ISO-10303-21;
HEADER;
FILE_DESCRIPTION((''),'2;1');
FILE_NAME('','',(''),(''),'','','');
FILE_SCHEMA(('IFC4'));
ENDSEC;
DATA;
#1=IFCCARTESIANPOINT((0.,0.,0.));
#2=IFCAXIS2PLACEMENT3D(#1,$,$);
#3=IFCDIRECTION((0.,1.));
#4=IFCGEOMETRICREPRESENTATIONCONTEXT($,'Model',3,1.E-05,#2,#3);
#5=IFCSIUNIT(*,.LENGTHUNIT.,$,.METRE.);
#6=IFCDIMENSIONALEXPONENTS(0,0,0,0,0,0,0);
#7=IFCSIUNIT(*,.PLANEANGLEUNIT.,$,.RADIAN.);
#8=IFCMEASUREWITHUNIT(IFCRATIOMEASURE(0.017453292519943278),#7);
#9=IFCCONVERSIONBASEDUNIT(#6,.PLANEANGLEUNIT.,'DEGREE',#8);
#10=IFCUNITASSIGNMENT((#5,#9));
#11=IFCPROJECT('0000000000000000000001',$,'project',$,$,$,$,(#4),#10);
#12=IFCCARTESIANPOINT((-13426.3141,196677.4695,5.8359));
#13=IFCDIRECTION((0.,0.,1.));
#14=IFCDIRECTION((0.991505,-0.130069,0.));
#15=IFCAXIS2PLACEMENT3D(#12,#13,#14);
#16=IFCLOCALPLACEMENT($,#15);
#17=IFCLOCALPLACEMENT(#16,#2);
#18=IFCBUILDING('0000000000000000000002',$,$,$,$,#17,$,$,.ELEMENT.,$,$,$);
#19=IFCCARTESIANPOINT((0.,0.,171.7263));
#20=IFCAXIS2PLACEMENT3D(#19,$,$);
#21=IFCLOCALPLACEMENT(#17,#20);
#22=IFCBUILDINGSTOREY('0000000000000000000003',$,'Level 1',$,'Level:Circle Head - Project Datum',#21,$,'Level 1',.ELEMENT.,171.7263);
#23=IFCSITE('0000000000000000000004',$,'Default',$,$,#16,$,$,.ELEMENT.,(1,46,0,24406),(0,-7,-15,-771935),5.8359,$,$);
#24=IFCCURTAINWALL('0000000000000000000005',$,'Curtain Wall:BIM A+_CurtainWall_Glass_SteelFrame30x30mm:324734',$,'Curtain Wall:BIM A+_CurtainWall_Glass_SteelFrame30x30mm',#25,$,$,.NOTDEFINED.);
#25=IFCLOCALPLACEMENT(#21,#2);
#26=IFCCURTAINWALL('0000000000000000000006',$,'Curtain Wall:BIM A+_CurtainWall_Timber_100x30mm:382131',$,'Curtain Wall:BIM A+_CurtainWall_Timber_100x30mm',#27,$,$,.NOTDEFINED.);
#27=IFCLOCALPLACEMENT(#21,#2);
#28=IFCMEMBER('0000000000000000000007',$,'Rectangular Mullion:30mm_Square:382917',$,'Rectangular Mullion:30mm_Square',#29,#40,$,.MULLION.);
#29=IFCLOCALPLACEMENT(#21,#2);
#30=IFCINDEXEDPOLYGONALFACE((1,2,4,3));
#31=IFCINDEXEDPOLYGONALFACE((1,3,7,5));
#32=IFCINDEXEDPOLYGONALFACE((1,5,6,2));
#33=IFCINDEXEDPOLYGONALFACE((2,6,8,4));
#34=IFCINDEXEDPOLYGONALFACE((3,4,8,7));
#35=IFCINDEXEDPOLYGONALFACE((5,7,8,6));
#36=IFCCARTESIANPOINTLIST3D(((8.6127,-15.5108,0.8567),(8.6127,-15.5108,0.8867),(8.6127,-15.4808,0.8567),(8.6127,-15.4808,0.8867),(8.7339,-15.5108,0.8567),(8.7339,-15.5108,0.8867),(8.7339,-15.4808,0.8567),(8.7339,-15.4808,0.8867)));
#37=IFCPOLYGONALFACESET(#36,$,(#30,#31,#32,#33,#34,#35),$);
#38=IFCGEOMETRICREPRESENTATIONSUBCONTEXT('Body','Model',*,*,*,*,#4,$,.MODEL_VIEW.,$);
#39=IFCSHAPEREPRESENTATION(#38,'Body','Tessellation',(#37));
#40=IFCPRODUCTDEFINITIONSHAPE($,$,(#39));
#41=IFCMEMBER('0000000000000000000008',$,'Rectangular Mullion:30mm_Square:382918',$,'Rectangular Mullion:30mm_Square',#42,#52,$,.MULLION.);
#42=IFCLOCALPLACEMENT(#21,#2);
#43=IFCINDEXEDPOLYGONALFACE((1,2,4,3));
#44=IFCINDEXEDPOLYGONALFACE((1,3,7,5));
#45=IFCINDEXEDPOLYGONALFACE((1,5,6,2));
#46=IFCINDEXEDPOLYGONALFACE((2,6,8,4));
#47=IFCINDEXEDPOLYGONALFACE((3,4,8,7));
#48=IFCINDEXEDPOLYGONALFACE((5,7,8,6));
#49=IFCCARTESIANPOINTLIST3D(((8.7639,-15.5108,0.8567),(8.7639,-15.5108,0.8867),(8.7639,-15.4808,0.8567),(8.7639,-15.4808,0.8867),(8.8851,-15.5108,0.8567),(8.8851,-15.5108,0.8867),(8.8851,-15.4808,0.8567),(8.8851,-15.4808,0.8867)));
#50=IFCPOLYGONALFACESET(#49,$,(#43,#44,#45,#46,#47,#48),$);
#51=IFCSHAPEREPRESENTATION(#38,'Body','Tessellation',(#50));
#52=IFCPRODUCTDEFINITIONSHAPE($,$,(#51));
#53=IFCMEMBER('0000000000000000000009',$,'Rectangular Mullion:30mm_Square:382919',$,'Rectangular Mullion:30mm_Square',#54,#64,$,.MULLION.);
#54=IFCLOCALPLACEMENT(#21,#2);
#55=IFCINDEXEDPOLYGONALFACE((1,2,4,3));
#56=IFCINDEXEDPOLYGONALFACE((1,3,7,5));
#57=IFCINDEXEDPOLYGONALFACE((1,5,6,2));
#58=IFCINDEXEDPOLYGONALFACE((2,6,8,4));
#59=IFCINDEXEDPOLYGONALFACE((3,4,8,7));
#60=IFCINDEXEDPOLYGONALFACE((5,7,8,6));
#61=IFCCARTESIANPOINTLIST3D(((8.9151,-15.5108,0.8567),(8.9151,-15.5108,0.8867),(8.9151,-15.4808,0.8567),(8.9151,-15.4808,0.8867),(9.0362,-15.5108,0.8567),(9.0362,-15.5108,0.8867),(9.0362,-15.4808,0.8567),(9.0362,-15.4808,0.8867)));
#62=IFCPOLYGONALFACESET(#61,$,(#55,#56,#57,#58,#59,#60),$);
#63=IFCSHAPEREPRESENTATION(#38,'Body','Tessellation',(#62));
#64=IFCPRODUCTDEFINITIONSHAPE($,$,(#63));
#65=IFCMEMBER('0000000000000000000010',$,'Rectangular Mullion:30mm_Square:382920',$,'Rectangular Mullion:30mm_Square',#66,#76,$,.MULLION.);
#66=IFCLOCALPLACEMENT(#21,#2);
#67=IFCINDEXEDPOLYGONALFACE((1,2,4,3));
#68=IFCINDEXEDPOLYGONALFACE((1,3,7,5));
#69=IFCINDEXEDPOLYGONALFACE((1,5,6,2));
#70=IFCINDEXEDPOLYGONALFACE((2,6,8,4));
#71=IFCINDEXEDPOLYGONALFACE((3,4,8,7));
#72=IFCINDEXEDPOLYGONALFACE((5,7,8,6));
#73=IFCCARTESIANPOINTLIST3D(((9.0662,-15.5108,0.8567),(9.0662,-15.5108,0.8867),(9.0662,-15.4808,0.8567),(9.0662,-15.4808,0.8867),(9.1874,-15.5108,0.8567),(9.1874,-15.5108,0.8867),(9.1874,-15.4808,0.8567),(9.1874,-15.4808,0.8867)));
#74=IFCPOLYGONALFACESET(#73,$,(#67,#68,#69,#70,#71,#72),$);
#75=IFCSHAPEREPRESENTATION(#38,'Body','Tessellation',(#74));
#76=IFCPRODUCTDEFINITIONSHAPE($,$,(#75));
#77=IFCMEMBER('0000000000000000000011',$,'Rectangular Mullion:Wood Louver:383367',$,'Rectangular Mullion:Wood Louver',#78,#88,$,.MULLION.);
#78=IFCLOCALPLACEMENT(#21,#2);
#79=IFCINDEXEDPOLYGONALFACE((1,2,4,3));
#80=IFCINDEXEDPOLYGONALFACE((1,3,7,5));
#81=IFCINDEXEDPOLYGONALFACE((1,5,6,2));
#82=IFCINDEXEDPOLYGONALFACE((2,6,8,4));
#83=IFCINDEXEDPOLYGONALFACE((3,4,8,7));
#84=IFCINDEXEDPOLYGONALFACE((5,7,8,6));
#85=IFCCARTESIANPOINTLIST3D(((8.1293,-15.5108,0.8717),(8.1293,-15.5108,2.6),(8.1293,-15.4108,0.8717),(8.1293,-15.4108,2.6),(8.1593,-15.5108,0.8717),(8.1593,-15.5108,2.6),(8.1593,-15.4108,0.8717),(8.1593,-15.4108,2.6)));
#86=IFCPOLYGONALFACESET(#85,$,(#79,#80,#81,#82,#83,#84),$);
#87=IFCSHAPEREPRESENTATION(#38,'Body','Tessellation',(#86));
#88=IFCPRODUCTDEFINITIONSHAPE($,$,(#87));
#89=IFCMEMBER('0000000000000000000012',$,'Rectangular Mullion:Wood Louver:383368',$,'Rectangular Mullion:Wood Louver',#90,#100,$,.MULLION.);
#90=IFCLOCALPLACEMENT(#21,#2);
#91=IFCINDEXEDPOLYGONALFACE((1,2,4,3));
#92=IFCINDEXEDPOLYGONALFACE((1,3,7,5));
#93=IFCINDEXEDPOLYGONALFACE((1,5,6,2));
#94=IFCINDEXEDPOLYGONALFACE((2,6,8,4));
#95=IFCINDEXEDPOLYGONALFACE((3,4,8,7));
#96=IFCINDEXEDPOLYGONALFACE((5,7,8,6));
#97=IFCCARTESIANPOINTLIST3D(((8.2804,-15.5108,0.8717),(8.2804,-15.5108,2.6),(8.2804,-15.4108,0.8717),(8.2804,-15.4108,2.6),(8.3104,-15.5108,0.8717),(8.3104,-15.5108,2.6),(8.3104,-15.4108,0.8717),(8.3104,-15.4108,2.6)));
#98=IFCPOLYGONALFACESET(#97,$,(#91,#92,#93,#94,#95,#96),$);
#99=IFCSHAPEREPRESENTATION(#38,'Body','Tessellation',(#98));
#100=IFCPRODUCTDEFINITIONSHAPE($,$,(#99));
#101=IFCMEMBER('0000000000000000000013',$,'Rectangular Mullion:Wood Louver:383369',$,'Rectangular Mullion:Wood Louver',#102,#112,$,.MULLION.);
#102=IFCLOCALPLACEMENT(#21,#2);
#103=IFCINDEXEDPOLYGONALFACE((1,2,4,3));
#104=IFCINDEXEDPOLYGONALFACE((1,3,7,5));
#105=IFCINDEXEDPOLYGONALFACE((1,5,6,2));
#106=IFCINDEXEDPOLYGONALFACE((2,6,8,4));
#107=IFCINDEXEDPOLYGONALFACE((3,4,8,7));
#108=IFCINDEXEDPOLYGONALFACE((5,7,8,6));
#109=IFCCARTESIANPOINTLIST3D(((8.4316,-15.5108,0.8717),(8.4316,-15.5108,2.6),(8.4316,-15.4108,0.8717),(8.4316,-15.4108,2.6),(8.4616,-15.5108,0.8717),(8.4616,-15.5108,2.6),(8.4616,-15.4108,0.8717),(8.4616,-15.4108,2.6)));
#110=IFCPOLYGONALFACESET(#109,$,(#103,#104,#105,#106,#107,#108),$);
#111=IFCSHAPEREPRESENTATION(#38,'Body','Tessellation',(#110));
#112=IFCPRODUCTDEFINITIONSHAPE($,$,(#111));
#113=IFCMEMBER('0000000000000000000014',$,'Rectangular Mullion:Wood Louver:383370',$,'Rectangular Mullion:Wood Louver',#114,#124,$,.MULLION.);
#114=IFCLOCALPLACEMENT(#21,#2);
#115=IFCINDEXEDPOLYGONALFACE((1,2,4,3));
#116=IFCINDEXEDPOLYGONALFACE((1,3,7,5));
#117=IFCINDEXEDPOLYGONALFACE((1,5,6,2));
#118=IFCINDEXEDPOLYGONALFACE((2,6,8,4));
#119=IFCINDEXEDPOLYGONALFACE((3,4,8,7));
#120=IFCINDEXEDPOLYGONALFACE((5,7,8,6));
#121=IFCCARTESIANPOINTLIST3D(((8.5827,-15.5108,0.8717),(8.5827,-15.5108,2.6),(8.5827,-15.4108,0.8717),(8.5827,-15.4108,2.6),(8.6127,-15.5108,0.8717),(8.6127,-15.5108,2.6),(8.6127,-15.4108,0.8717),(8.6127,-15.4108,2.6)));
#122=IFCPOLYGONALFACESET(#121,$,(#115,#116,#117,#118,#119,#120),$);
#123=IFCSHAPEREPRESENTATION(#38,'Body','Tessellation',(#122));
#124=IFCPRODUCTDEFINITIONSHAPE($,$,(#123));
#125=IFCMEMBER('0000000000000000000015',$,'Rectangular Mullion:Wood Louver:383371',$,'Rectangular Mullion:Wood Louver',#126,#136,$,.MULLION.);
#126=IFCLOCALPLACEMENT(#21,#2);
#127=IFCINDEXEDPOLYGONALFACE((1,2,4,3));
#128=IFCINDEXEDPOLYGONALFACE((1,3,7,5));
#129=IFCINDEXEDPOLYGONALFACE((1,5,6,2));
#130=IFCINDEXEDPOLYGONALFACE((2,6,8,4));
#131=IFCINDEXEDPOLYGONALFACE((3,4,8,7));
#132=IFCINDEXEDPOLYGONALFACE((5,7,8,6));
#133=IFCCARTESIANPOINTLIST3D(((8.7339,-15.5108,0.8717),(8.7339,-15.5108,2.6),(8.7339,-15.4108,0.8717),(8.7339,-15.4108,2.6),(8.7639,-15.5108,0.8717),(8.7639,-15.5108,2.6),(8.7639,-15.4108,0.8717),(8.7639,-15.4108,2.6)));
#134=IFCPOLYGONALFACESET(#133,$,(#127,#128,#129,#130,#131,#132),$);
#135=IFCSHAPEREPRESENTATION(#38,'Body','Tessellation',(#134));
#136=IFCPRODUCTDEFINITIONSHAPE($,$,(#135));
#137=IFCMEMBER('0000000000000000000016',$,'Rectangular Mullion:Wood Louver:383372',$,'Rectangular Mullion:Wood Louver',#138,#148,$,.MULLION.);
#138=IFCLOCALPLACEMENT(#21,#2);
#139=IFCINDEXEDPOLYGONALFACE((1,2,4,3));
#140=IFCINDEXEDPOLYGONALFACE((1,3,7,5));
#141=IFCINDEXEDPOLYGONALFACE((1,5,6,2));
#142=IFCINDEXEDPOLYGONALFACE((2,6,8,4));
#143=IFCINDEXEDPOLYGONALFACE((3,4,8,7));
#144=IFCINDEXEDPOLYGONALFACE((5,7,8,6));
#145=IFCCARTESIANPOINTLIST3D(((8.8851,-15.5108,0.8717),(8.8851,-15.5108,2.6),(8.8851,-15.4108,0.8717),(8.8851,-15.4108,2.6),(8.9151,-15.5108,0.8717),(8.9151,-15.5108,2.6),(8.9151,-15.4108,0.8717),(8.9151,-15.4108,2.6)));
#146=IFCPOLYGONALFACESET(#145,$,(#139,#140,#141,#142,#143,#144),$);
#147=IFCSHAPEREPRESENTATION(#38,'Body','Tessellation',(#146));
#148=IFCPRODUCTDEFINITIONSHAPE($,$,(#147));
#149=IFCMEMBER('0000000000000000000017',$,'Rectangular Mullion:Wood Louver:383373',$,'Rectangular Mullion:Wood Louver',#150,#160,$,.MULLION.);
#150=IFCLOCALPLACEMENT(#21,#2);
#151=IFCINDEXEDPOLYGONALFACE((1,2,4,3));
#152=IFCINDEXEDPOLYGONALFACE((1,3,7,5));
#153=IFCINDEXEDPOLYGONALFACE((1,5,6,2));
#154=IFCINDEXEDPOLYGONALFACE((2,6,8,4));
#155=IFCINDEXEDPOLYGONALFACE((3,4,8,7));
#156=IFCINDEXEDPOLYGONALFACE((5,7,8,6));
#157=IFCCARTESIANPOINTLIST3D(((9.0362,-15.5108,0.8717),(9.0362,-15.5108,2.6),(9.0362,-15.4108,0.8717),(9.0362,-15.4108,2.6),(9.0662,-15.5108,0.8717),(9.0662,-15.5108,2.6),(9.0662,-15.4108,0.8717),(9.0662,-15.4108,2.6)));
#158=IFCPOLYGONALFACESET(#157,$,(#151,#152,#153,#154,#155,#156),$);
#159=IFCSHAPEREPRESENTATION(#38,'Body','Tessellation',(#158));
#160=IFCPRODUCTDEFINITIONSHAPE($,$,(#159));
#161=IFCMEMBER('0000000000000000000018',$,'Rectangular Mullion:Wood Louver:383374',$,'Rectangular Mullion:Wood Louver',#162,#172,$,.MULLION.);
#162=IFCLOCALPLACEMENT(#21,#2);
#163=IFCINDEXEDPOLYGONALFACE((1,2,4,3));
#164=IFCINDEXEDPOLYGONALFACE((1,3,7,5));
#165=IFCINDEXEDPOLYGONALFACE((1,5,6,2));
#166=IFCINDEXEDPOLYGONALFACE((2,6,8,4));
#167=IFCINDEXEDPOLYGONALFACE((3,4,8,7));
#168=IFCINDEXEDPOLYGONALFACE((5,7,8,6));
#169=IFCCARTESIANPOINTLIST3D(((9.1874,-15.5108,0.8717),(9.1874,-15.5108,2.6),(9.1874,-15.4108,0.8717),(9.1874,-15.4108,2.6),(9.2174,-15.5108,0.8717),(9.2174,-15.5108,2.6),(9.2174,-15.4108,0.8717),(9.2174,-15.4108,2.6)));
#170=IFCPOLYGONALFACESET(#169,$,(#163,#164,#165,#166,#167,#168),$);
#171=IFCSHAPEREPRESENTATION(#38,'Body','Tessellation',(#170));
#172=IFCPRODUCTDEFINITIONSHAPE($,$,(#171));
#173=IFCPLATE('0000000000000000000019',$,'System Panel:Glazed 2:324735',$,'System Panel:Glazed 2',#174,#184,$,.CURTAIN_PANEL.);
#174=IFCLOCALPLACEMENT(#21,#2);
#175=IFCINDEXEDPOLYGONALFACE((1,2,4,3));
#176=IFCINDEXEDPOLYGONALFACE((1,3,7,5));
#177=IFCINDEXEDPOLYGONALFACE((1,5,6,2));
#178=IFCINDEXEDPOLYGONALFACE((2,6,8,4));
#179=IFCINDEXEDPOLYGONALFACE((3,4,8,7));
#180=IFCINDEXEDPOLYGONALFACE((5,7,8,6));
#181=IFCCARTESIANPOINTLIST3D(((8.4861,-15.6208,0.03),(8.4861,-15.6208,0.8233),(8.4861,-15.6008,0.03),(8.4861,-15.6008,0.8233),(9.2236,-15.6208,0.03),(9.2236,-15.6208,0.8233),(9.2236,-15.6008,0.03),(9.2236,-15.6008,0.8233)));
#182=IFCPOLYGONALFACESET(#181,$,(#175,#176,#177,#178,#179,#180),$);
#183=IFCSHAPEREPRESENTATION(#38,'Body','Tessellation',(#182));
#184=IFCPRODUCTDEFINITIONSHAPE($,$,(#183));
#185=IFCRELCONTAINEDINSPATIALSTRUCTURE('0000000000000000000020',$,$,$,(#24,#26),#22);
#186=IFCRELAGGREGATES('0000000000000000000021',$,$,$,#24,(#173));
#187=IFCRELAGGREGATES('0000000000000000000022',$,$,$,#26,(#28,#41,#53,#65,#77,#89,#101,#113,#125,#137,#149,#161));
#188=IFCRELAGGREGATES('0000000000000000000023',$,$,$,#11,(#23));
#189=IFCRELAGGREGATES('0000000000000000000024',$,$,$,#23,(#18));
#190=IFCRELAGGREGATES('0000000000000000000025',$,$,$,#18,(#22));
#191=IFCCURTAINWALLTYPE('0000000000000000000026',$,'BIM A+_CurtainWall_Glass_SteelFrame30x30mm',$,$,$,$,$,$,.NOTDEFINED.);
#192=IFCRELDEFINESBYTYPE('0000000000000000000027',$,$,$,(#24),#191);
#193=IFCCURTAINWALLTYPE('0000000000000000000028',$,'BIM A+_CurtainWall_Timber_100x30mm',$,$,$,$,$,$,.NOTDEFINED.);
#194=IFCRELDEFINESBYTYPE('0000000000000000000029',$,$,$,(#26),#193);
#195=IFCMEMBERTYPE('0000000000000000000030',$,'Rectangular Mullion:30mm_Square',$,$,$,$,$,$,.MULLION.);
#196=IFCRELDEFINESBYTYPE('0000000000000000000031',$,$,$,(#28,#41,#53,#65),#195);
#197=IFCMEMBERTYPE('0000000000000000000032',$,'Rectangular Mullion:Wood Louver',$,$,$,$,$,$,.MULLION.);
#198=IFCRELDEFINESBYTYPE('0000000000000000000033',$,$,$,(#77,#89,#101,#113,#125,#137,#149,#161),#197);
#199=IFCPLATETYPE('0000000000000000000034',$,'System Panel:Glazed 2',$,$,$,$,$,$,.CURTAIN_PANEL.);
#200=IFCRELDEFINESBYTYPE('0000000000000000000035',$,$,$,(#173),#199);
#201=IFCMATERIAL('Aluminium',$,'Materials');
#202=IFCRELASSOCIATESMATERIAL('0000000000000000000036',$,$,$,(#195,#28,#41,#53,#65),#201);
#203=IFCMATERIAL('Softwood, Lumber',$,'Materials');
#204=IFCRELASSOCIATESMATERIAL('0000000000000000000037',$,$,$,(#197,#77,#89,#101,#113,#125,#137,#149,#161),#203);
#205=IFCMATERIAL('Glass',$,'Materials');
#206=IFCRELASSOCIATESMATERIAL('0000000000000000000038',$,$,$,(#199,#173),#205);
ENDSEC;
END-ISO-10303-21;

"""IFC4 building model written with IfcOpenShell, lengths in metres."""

from ifc_helpers import new_model, entity, si_unit, converted_unit, direction, frame, origin, place, context, subcontext, project, spatial, indexed_curve, outline, extrude, source, transform, mapped, material, type_object, type_shapes, element, aggregate, save


model = new_model("IFC4")

# Units and contexts
model_context = context("Model", 3, precision=1e-05, world=origin(), true_north=direction((0.0, 1.0)))
body_context = subcontext(model_context, "Body", "Model", "MODEL_VIEW")
ifc_project = project(units=[si_unit("LENGTHUNIT", "METRE"), converted_unit("PLANEANGLEUNIT", "DEGREE", entity("IfcRatioMeasure", 0.017453292519943278), si_unit("PLANEANGLEUNIT", "RADIAN"), dimensions=[0, 0, 0, 0, 0, 0, 0])], contexts=[model_context])

# Site, building, storey
site_placement = place(None, frame((-13426.3141, 196677.4695, 5.8359), z_axis=(0.0, 0.0, 1.0), x_axis=(0.991505, -0.130069, 0.0)))
site = spatial("IfcSite", under=ifc_project, at=site_placement, Name="Default", CompositionType="ELEMENT", RefLatitude=(1, 46, 0, 24406), RefLongitude=(0, -7, -15, -771935), RefElevation=5.8359)
building_placement = place(site_placement, origin())
building = spatial("IfcBuilding", under=site, at=building_placement, CompositionType="ELEMENT")
storey_placement = place(building_placement, frame((0.0, 0.0, 171.7263)))
storey = spatial("IfcBuildingStorey", under=building, at=storey_placement, Name="Level 1", ObjectType="Level:Circle Head - Project Datum", LongName="Level 1", CompositionType="ELEMENT", Elevation=171.7263)

# Curtain walls, members
curtain_wall_type_1 = type_object("IfcCurtainWallType", Name="BIM A+_CurtainWall_Glass_SteelFrame30x30mm", PredefinedType="NOTDEFINED")
curtain_wall_1_placement = place(storey_placement, frame((0.0, 0.0, -171.7263)))
curtain_wall_1 = element("IfcCurtainWall", 1, at=curtain_wall_1_placement, inside=storey, type_object=curtain_wall_type_1, Name="Curtain Wall:BIM A+_CurtainWall_Glass_SteelFrame30x30mm:324734", ObjectType="Curtain Wall:BIM A+_CurtainWall_Glass_SteelFrame30x30mm", PredefinedType="NOTDEFINED")
ifc_material_1 = material(Name="Aluminium", Category="Materials")
curtain_wall_type_2 = type_object("IfcCurtainWallType", Name="BIM A+_CurtainWall_Timber_100x30mm", PredefinedType="NOTDEFINED")
curtain_wall_2_placement = place(storey_placement, frame((0.0, 0.0, -171.7263)))
curtain_wall_2 = element("IfcCurtainWall", 2, at=curtain_wall_2_placement, inside=storey, type_object=curtain_wall_type_2, Name="Curtain Wall:BIM A+_CurtainWall_Timber_100x30mm:382131", ObjectType="Curtain Wall:BIM A+_CurtainWall_Timber_100x30mm", PredefinedType="NOTDEFINED")
member_type_1 = type_object("IfcMemberType", Name="Rectangular Mullion:30mm_Square", PredefinedType="MULLION", material=ifc_material_1)
shared_shape_1 = source(origin(), body_context, "Body", "SweptSolid", [
    extrude(outline(indexed_curve([(-0.015, -0.015), (0.015, -0.015), (0.015, 0.015), (-0.015, 0.015), (-0.015, -0.015)], self_intersect=False)), frame((0.0, 0.0, -0.1212), z_axis=(0.0, 0.0, 1.0), x_axis=(0.0, -1.0, 0.0)), (0.0, 0.0, 1.0), 0.1212),
])
type_shapes(member_type_1, [shared_shape_1])
member_1_placement = place(curtain_wall_2_placement, frame((8.7339, -15.4958, 172.598), z_axis=(1.0, 0.0, 0.0), x_axis=(0.0, 0.0, 1.0)))
member_1 = element("IfcMember", 3, at=member_1_placement, type_object=member_type_1, material=ifc_material_1, Name="Rectangular Mullion:30mm_Square:382917", ObjectType="Rectangular Mullion:30mm_Square", PredefinedType="MULLION", context=body_context, shape_type="MappedRepresentation", body=[
    mapped(shared_shape_1, transform((0.0, 0.0, 0.0), scale=1.0)),
])
member_2_placement = place(curtain_wall_2_placement, frame((8.8851, -15.4958, 172.598), z_axis=(1.0, 0.0, 0.0), x_axis=(0.0, 0.0, 1.0)))
member_2 = element("IfcMember", 4, at=member_2_placement, type_object=member_type_1, material=ifc_material_1, Name="Rectangular Mullion:30mm_Square:382918", ObjectType="Rectangular Mullion:30mm_Square", PredefinedType="MULLION", context=body_context, shape_type="MappedRepresentation", body=[
    mapped(shared_shape_1, transform((0.0, 0.0, 0.0), scale=1.0)),
])
member_3_placement = place(curtain_wall_2_placement, frame((9.0362, -15.4958, 172.598), z_axis=(1.0, 0.0, 0.0), x_axis=(0.0, 0.0, 1.0)))
member_3 = element("IfcMember", 5, at=member_3_placement, type_object=member_type_1, material=ifc_material_1, Name="Rectangular Mullion:30mm_Square:382919", ObjectType="Rectangular Mullion:30mm_Square", PredefinedType="MULLION", context=body_context, shape_type="MappedRepresentation", body=[
    mapped(shared_shape_1, transform((0.0, 0.0, 0.0), scale=1.0)),
])
member_4_placement = place(curtain_wall_2_placement, frame((9.1874, -15.4958, 172.598), z_axis=(1.0, 0.0, 0.0), x_axis=(0.0, 0.0, 1.0)))
member_4 = element("IfcMember", 6, at=member_4_placement, type_object=member_type_1, material=ifc_material_1, Name="Rectangular Mullion:30mm_Square:382920", ObjectType="Rectangular Mullion:30mm_Square", PredefinedType="MULLION", context=body_context, shape_type="MappedRepresentation", body=[
    mapped(shared_shape_1, transform((0.0, 0.0, 0.0), scale=1.0)),
])
ifc_material_2 = material(Name="Softwood, Lumber", Category="Materials")
member_type_2 = type_object("IfcMemberType", Name="Rectangular Mullion:Wood Louver", PredefinedType="MULLION", material=ifc_material_2)
shared_shape_2 = source(origin(), body_context, "Body", "SweptSolid", [
    extrude(outline(indexed_curve([(-0.05, -0.015), (0.05, -0.015), (0.05, 0.015), (-0.05, 0.015), (-0.05, -0.015)], self_intersect=False)), frame((0.0, -0.035, -1.7283), z_axis=(0.0, 0.0, 1.0), x_axis=(0.0, -1.0, 0.0)), (0.0, 0.0, 1.0), 1.7283),
])
type_shapes(member_type_2, [shared_shape_2])
member_5_placement = place(curtain_wall_2_placement, frame((8.1443, -15.4958, 172.598), z_axis=(0.0, 0.0, -1.0), x_axis=(1.0, 0.0, 0.0)))
member_5 = element("IfcMember", 7, at=member_5_placement, type_object=member_type_2, material=ifc_material_2, Name="Rectangular Mullion:Wood Louver:383367", ObjectType="Rectangular Mullion:Wood Louver", PredefinedType="MULLION", context=body_context, shape_type="MappedRepresentation", body=[
    mapped(shared_shape_2, transform((0.0, 0.0, 0.0), scale=1.0)),
])
member_6_placement = place(curtain_wall_2_placement, frame((8.2954, -15.4958, 172.598), z_axis=(0.0, 0.0, -1.0), x_axis=(1.0, 0.0, 0.0)))
member_6 = element("IfcMember", 8, at=member_6_placement, type_object=member_type_2, material=ifc_material_2, Name="Rectangular Mullion:Wood Louver:383368", ObjectType="Rectangular Mullion:Wood Louver", PredefinedType="MULLION", context=body_context, shape_type="MappedRepresentation", body=[
    mapped(shared_shape_2, transform((0.0, 0.0, 0.0), scale=1.0)),
])
member_7_placement = place(curtain_wall_2_placement, frame((8.4466, -15.4958, 172.598), z_axis=(0.0, 0.0, -1.0), x_axis=(1.0, 0.0, 0.0)))
member_7 = element("IfcMember", 9, at=member_7_placement, type_object=member_type_2, material=ifc_material_2, Name="Rectangular Mullion:Wood Louver:383369", ObjectType="Rectangular Mullion:Wood Louver", PredefinedType="MULLION", context=body_context, shape_type="MappedRepresentation", body=[
    mapped(shared_shape_2, transform((0.0, 0.0, 0.0), scale=1.0)),
])
member_8_placement = place(curtain_wall_2_placement, frame((8.5977, -15.4958, 172.598), z_axis=(0.0, 0.0, -1.0), x_axis=(1.0, 0.0, 0.0)))
member_8 = element("IfcMember", 10, at=member_8_placement, type_object=member_type_2, material=ifc_material_2, Name="Rectangular Mullion:Wood Louver:383370", ObjectType="Rectangular Mullion:Wood Louver", PredefinedType="MULLION", context=body_context, shape_type="MappedRepresentation", body=[
    mapped(shared_shape_2, transform((0.0, 0.0, 0.0), scale=1.0)),
])
member_9_placement = place(curtain_wall_2_placement, frame((8.7489, -15.4958, 172.598), z_axis=(0.0, 0.0, -1.0), x_axis=(1.0, 0.0, 0.0)))
member_9 = element("IfcMember", 11, at=member_9_placement, type_object=member_type_2, material=ifc_material_2, Name="Rectangular Mullion:Wood Louver:383371", ObjectType="Rectangular Mullion:Wood Louver", PredefinedType="MULLION", context=body_context, shape_type="MappedRepresentation", body=[
    mapped(shared_shape_2, transform((0.0, 0.0, 0.0), scale=1.0)),
])
member_10_placement = place(curtain_wall_2_placement, frame((8.9001, -15.4958, 172.598), z_axis=(0.0, 0.0, -1.0), x_axis=(1.0, 0.0, 0.0)))
member_10 = element("IfcMember", 12, at=member_10_placement, type_object=member_type_2, material=ifc_material_2, Name="Rectangular Mullion:Wood Louver:383372", ObjectType="Rectangular Mullion:Wood Louver", PredefinedType="MULLION", context=body_context, shape_type="MappedRepresentation", body=[
    mapped(shared_shape_2, transform((0.0, 0.0, 0.0), scale=1.0)),
])
member_11_placement = place(curtain_wall_2_placement, frame((9.0512, -15.4958, 172.598), z_axis=(0.0, 0.0, -1.0), x_axis=(1.0, 0.0, 0.0)))
member_11 = element("IfcMember", 13, at=member_11_placement, type_object=member_type_2, material=ifc_material_2, Name="Rectangular Mullion:Wood Louver:383373", ObjectType="Rectangular Mullion:Wood Louver", PredefinedType="MULLION", context=body_context, shape_type="MappedRepresentation", body=[
    mapped(shared_shape_2, transform((0.0, 0.0, 0.0), scale=1.0)),
])
member_12_placement = place(curtain_wall_2_placement, frame((9.2024, -15.4958, 172.598), z_axis=(0.0, 0.0, -1.0), x_axis=(1.0, 0.0, 0.0)))
member_12 = element("IfcMember", 14, at=member_12_placement, type_object=member_type_2, material=ifc_material_2, Name="Rectangular Mullion:Wood Louver:383374", ObjectType="Rectangular Mullion:Wood Louver", PredefinedType="MULLION", context=body_context, shape_type="MappedRepresentation", body=[
    mapped(shared_shape_2, transform((0.0, 0.0, 0.0), scale=1.0)),
])

# Plate
ifc_material_3 = material(Name="Glass", Category="Materials")
plate_type_1 = type_object("IfcPlateType", Name="System Panel:Glazed 2", PredefinedType="CURTAIN_PANEL", material=ifc_material_3)
shared_shape_3 = source(origin(), body_context, "Body", "SweptSolid", [
    extrude(outline(indexed_curve([(-0.01, -0.3688), (0.01, -0.3688), (0.01, 0.3688), (-0.01, 0.3688), (-0.01, -0.3688)], self_intersect=False)), frame((0.0, 0.0, 0.0), z_axis=(0.0, 0.0, 1.0), x_axis=(0.0, 1.0, 0.0)), (0.0, 0.0, 1.0), 0.7933),
])
type_shapes(plate_type_1, [shared_shape_3])
plate_1_placement = place(curtain_wall_1_placement, frame((8.8548, -15.6108, 171.7563), z_axis=(0.0, 0.0, 1.0), x_axis=(-1.0, 0.0, 0.0)))
plate_1 = element("IfcPlate", 15, at=plate_1_placement, type_object=plate_type_1, material=ifc_material_3, Name="System Panel:Glazed 2:324735", ObjectType="System Panel:Glazed 2", PredefinedType="CURTAIN_PANEL", context=body_context, shape_type="MappedRepresentation", body=[
    mapped(shared_shape_3, transform((0.0, 0.0, 0.0), scale=1.0)),
])
aggregate(curtain_wall_1, [plate_1])
aggregate(curtain_wall_2, [member_1, member_2, member_3, member_4, member_5, member_6, member_7, member_8, member_9, member_10, member_11, member_12])

save(model, "model.ifc")
